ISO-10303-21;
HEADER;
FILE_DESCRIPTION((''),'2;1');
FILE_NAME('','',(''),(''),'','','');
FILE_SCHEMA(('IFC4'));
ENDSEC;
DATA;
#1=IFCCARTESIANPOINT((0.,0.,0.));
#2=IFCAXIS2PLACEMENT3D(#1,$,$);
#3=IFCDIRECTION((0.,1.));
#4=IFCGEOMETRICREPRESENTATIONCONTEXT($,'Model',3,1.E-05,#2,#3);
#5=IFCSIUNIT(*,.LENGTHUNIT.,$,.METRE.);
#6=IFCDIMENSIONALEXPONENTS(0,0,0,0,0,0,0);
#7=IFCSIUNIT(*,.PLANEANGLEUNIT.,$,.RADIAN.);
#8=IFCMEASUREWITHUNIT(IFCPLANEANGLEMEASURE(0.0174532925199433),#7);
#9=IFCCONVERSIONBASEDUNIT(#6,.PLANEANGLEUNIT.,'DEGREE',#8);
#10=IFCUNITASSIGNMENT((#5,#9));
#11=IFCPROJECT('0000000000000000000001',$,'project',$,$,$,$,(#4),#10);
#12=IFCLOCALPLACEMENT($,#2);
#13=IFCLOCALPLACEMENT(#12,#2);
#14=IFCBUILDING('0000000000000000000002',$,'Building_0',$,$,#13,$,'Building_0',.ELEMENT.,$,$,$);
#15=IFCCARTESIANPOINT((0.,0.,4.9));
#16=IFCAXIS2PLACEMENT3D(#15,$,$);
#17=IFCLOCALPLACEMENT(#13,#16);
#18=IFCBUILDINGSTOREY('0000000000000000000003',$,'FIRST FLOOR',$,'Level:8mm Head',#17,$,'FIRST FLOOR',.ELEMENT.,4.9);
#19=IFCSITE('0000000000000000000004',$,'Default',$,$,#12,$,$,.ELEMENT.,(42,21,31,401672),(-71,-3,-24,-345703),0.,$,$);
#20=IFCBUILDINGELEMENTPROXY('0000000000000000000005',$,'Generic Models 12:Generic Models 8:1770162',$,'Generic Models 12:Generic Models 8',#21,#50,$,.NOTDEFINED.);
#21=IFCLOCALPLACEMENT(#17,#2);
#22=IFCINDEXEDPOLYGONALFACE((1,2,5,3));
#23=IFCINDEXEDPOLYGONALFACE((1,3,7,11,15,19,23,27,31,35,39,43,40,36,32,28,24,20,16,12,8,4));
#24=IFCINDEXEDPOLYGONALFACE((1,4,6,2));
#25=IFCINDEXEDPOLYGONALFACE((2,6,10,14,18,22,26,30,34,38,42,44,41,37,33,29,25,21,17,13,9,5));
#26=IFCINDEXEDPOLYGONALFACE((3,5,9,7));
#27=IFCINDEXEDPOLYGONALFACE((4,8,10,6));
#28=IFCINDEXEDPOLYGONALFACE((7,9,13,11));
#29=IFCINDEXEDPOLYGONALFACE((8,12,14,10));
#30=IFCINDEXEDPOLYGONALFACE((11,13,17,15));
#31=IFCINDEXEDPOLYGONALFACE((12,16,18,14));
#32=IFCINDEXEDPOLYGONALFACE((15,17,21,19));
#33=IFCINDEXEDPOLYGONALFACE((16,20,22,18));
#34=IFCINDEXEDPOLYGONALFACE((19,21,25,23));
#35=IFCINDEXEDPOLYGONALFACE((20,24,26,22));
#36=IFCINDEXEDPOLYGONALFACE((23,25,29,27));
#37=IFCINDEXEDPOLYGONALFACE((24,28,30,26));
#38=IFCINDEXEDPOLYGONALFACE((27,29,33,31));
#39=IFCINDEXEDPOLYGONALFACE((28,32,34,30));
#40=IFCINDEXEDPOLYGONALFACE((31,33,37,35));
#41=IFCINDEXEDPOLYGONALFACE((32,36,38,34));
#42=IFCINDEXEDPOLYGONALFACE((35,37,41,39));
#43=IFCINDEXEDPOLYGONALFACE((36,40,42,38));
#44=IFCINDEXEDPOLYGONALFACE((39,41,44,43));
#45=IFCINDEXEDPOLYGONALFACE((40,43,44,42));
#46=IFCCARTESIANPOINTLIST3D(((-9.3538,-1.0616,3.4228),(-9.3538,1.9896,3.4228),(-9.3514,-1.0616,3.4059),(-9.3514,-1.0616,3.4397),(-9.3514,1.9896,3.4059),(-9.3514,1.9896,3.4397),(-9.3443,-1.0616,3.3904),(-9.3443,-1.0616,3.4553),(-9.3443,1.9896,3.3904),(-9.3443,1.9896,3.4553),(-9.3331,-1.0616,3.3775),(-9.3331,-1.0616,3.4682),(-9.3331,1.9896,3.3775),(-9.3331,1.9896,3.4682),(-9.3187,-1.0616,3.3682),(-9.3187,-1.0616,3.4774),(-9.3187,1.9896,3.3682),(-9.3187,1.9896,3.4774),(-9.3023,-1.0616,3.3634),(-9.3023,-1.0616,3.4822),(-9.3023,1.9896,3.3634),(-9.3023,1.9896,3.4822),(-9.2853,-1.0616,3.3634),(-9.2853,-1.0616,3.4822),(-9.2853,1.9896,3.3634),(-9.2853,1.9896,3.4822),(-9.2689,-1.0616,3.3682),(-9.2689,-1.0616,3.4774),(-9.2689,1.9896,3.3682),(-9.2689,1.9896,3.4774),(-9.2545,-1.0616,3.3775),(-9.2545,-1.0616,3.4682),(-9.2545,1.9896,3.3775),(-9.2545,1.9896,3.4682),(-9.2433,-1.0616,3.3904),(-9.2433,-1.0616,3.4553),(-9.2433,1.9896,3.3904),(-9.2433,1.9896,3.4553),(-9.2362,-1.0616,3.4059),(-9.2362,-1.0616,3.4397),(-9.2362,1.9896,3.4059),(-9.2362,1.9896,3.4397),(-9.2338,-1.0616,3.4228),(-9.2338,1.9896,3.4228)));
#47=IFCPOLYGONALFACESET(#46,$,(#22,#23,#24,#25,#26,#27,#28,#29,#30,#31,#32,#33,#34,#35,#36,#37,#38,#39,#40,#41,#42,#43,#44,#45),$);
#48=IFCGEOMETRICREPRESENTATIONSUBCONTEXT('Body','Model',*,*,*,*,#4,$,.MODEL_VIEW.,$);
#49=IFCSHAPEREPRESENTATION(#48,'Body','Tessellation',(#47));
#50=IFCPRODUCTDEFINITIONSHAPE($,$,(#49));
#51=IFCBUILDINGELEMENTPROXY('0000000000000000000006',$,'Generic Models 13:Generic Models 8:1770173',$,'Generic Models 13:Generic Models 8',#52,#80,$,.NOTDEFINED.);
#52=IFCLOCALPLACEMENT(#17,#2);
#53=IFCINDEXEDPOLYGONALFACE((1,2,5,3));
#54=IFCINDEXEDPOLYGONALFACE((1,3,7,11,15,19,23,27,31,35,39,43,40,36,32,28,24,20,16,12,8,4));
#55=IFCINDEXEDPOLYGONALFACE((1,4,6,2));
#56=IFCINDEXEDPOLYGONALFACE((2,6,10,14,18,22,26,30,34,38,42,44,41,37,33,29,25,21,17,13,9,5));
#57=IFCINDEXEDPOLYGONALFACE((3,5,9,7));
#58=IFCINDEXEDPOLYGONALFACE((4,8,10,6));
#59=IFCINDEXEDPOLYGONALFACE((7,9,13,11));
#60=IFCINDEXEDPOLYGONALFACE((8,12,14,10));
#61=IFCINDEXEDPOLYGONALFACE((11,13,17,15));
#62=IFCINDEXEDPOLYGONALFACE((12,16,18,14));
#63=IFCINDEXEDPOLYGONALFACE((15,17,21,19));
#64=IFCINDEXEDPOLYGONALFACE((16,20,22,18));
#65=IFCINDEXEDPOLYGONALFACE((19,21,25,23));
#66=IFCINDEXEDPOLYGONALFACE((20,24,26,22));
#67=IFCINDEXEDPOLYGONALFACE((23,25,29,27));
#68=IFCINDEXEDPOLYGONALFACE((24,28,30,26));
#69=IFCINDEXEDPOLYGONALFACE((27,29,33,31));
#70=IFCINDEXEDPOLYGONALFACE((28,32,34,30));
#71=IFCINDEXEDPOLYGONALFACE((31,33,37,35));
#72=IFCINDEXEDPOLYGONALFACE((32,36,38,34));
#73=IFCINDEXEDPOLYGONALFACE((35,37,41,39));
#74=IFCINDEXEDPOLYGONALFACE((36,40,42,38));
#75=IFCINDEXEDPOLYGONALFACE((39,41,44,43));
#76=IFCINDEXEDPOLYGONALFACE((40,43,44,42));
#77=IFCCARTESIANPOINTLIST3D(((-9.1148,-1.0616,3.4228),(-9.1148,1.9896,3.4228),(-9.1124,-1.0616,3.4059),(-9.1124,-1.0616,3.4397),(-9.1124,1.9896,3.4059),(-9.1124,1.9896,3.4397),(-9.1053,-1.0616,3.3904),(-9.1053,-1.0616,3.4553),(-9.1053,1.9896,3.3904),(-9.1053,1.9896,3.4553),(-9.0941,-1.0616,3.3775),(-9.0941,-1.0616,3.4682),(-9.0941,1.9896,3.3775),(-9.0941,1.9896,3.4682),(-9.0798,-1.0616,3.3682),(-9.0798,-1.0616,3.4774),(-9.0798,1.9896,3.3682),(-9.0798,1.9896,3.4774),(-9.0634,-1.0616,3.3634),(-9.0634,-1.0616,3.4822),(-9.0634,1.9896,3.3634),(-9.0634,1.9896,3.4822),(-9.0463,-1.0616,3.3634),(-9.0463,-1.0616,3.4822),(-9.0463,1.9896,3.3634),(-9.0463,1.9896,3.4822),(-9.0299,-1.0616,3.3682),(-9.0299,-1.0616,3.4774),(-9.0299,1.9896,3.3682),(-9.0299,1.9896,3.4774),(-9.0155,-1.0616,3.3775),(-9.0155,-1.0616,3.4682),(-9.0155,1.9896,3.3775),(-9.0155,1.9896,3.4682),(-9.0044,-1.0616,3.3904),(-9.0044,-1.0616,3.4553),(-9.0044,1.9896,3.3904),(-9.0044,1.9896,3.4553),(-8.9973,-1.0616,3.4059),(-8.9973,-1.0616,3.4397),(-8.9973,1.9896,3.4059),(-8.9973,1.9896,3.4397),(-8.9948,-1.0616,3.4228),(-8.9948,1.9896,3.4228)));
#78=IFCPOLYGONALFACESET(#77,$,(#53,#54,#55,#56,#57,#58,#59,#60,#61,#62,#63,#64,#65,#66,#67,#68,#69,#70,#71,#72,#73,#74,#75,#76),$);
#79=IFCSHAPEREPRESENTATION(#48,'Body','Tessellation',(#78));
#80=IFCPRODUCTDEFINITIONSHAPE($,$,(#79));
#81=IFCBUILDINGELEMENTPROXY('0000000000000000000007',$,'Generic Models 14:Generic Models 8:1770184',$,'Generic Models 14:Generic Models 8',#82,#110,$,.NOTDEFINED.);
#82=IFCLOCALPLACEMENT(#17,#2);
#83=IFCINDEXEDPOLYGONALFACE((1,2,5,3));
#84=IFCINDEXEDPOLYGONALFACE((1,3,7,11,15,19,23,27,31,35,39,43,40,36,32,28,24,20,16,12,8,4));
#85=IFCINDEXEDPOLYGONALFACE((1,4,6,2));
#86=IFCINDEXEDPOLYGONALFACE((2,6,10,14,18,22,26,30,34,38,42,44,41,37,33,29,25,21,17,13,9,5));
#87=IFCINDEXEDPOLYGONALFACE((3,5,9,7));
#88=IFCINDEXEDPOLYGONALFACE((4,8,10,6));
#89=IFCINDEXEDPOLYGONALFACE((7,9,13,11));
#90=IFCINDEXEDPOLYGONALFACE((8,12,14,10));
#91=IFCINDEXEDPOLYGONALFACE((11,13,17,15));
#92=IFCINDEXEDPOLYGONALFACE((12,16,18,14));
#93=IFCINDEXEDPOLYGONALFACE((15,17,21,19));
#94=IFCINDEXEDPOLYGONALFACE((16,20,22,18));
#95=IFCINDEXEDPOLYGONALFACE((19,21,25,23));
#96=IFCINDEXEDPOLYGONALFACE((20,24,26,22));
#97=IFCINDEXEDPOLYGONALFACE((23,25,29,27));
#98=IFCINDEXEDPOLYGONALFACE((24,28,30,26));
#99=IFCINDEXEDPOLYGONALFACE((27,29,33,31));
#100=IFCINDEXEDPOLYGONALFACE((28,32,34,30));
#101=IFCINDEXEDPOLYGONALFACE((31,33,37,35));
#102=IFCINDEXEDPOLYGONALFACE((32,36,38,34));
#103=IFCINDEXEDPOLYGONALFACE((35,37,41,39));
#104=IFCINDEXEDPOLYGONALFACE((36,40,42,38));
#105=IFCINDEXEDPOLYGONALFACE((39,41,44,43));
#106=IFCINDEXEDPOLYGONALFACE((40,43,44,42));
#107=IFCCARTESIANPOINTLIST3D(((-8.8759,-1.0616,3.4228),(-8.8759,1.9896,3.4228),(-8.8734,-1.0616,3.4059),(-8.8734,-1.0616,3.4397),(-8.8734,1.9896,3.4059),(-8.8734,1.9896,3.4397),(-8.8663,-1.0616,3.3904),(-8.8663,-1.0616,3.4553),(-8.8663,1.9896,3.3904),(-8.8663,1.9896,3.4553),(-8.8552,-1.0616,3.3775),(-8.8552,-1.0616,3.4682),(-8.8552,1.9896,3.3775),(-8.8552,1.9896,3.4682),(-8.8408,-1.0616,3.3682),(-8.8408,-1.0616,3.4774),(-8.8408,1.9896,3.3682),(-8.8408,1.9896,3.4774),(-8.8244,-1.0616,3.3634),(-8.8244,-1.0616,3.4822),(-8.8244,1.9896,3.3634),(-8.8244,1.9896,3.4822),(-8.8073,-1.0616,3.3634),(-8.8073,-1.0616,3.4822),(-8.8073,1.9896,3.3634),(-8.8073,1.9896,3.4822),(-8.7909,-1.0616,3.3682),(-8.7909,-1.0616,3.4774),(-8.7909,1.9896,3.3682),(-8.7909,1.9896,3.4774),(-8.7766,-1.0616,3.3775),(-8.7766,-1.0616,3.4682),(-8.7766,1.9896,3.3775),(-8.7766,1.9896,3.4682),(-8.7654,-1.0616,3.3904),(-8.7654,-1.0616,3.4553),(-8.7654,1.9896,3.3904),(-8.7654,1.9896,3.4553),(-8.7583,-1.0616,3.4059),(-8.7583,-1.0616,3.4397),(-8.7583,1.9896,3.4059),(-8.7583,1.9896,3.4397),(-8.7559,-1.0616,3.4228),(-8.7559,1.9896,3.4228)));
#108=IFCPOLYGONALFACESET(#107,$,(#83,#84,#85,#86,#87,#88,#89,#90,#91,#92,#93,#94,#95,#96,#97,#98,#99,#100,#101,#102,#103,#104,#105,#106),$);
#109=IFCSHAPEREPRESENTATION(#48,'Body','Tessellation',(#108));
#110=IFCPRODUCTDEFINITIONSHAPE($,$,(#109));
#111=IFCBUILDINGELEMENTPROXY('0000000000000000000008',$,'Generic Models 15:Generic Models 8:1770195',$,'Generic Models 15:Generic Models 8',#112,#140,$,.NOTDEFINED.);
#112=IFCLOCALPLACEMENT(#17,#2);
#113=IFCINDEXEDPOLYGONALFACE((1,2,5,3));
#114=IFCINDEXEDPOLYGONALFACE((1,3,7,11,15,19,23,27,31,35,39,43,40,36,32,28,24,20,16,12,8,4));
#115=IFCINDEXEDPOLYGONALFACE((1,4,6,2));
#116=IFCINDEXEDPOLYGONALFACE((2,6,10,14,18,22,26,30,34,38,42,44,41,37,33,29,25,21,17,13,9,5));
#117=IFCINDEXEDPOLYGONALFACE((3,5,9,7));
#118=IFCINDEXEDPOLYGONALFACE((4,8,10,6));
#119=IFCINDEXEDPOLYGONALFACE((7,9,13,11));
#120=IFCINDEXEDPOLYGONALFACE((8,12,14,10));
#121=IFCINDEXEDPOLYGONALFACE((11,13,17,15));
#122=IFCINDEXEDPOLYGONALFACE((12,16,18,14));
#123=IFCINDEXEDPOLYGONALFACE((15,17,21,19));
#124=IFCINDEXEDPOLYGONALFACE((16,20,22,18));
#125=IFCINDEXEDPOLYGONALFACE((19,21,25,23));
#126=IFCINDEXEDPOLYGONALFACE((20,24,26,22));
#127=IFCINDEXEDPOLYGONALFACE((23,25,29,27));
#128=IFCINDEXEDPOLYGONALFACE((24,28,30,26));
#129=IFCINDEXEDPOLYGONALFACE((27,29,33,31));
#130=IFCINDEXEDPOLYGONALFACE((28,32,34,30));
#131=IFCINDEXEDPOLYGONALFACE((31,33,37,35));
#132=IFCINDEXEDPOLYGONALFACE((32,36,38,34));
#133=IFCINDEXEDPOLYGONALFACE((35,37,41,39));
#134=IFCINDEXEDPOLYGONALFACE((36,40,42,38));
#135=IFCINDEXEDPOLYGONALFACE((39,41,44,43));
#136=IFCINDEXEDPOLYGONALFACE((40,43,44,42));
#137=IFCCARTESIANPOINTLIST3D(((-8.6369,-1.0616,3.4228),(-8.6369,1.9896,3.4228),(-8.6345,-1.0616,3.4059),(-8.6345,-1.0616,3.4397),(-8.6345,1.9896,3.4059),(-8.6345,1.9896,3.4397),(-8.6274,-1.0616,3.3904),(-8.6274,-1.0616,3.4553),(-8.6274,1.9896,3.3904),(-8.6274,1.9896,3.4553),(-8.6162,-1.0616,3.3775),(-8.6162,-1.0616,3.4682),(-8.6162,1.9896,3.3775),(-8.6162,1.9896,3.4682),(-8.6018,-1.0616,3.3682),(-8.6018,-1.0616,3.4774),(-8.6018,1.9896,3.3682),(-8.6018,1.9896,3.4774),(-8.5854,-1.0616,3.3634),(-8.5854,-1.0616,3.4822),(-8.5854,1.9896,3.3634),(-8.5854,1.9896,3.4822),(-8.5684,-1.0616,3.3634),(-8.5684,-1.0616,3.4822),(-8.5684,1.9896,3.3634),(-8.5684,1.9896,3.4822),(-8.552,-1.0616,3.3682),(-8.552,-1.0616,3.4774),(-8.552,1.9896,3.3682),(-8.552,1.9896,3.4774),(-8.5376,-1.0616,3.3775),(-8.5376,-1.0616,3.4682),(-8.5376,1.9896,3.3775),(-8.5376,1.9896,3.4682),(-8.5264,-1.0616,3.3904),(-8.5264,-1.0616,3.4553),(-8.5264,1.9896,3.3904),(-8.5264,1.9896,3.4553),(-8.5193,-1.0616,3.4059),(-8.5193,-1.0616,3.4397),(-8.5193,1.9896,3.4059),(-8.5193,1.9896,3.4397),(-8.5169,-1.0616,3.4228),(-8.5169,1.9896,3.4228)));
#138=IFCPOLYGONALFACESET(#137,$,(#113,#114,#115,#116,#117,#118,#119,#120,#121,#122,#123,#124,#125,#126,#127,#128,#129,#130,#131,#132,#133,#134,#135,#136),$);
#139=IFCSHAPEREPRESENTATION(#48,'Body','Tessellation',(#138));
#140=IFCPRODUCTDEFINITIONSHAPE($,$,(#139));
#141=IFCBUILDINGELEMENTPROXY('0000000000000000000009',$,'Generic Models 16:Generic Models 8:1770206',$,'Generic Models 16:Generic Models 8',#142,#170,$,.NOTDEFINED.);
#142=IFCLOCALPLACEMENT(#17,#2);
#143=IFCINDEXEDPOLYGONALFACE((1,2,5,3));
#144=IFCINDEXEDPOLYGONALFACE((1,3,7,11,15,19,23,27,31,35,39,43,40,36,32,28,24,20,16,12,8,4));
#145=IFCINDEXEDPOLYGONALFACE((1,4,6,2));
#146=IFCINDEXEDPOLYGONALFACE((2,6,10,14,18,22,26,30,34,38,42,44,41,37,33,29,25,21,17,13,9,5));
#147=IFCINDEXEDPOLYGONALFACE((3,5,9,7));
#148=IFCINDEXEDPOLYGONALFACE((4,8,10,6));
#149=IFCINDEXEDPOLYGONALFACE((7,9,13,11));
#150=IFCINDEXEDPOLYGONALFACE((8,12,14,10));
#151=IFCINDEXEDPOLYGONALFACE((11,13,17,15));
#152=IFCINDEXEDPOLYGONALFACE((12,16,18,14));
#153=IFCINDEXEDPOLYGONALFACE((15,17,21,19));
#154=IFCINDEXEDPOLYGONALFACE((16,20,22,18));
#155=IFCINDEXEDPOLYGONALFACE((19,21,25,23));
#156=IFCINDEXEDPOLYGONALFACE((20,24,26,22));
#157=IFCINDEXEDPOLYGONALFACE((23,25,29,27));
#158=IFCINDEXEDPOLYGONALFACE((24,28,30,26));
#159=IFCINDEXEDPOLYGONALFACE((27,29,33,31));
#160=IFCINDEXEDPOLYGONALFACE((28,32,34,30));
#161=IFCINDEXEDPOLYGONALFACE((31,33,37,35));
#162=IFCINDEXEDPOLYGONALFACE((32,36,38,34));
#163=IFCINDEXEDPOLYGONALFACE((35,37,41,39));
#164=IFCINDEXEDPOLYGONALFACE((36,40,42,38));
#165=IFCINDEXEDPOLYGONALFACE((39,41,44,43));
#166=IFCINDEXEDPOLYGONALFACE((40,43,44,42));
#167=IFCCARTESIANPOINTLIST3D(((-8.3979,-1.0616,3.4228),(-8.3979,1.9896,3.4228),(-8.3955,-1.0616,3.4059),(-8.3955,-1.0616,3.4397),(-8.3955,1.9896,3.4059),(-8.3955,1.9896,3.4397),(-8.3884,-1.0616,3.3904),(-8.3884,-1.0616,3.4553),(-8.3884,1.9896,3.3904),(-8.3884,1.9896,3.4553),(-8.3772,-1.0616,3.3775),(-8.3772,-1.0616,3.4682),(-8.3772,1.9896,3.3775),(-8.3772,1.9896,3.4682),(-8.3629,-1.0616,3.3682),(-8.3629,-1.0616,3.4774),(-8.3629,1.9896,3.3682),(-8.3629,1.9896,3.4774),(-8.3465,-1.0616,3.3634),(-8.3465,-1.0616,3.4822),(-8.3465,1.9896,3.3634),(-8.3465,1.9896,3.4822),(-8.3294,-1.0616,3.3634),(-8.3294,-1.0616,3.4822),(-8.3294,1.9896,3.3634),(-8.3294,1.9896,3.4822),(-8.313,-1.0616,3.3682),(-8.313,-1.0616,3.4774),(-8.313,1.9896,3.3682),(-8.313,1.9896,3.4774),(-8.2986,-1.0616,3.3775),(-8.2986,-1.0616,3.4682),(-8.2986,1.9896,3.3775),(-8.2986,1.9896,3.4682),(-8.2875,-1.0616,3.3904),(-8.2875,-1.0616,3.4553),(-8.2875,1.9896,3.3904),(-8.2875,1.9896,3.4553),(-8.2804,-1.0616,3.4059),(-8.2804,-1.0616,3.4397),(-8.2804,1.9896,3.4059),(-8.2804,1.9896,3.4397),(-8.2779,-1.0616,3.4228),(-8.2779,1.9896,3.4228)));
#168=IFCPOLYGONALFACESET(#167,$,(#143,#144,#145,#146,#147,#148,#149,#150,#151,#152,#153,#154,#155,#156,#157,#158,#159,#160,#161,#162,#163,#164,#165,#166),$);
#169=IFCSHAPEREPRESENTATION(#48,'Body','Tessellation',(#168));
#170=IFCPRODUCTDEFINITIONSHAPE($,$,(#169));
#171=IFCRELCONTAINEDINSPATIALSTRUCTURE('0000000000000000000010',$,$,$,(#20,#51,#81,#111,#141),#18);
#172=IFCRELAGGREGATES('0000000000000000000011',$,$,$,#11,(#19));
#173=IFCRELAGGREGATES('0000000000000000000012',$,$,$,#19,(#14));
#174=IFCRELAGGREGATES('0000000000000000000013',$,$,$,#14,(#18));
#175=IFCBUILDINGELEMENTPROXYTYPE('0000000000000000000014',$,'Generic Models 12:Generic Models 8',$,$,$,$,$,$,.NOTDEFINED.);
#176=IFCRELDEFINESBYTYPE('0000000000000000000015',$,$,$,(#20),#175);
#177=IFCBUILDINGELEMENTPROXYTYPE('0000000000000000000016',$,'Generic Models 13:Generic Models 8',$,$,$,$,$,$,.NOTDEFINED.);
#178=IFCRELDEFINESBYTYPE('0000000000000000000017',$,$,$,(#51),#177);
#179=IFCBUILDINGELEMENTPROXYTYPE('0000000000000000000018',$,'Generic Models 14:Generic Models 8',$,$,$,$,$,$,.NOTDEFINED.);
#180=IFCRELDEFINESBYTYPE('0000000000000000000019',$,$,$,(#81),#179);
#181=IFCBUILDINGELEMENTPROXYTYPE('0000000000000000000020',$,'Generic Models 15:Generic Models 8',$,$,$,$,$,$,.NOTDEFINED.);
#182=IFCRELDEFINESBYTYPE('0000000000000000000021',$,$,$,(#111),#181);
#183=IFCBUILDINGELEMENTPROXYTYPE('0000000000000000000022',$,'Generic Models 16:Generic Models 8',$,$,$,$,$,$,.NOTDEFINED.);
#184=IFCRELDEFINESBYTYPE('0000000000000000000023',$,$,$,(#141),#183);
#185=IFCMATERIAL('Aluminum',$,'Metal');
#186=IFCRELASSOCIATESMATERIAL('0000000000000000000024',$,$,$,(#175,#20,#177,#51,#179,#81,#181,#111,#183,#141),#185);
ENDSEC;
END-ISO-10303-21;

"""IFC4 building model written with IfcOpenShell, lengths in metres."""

from ifc_helpers import new_model, entity, si_unit, converted_unit, direction, frame, origin, place, context, subcontext, project, spatial, arc, indexed_curve, outline, extrude, source, transform, mapped, material, type_object, type_shapes, element, save


model = new_model("IFC4")

# Units and contexts
model_context = context("Model", 3, precision=1e-05, world=origin(), true_north=direction((0.0, 1.0)))
body_context = subcontext(model_context, "Body", "Model", "MODEL_VIEW")
ifc_project = project(units=[si_unit("LENGTHUNIT", "METRE"), converted_unit("PLANEANGLEUNIT", "DEGREE", entity("IfcPlaneAngleMeasure", 0.0174532925199433), si_unit("PLANEANGLEUNIT", "RADIAN"), dimensions=[0, 0, 0, 0, 0, 0, 0])], contexts=[model_context])

# Site, building, storey
site_placement = place(None, origin())
site = spatial("IfcSite", under=ifc_project, at=site_placement, Name="Default", CompositionType="ELEMENT", RefLatitude=(42, 21, 31, 401672), RefLongitude=(-71, -3, -24, -345703), RefElevation=0.0)
building_placement = place(site_placement, origin())
building = spatial("IfcBuilding", under=site, at=building_placement, Name="Building_0", LongName="Building_0", CompositionType="ELEMENT")
storey_placement = place(building_placement, frame((0.0, 0.0, 4.9)))
storey = spatial("IfcBuildingStorey", under=building, at=storey_placement, Name="FIRST FLOOR", ObjectType="Level:8mm Head", LongName="FIRST FLOOR", CompositionType="ELEMENT", Elevation=4.9)

# Building element proxies
ifc_material = material(Name="Aluminum", Category="Metal")
building_element_proxy_type_1 = type_object("IfcBuildingElementProxyType", Name="Generic Models 12:Generic Models 8", PredefinedType="NOTDEFINED", material=ifc_material)
shared_shape_1 = source(origin(), body_context, "Body", "SweptSolid", [
    extrude(outline(indexed_curve([(-0.06, 0.0), (0.0, -0.06), (0.06, 0.0), (0.0, 0.06)], segments=[arc(1, 2, 3), arc(3, 4, 1)], self_intersect=False)), frame((-9.2938, -1.0616, 8.3228), z_axis=(0.0, 1.0, 0.0), x_axis=(-1.0, 0.0, 0.0)), (0.0, 0.0, 1.0), 3.0512),
])
type_shapes(building_element_proxy_type_1, [shared_shape_1])
proxy_1_placement = place(storey_placement, frame((0.0, 0.0, -4.9)))
element("IfcBuildingElementProxy", 1, at=proxy_1_placement, inside=storey, type_object=building_element_proxy_type_1, material=ifc_material, Name="Generic Models 12:Generic Models 8:1770162", ObjectType="Generic Models 12:Generic Models 8", PredefinedType="NOTDEFINED", context=body_context, shape_type="MappedRepresentation", body=[
    mapped(shared_shape_1, transform((0.0, 0.0, 0.0), scale=1.0)),
])
building_element_proxy_type_2 = type_object("IfcBuildingElementProxyType", Name="Generic Models 13:Generic Models 8", PredefinedType="NOTDEFINED", material=ifc_material)
shared_shape_2 = source(origin(), body_context, "Body", "SweptSolid", [
    extrude(outline(indexed_curve([(-0.06, 0.0), (0.0, -0.06), (0.06, 0.0), (0.0, 0.06)], segments=[arc(1, 2, 3), arc(3, 4, 1)], self_intersect=False)), frame((-9.0548, -1.0616, 8.3228), z_axis=(0.0, 1.0, 0.0), x_axis=(-1.0, 0.0, 0.0)), (0.0, 0.0, 1.0), 3.0512),
])
type_shapes(building_element_proxy_type_2, [shared_shape_2])
proxy_2_placement = place(storey_placement, frame((0.0, 0.0, -4.9)))
element("IfcBuildingElementProxy", 2, at=proxy_2_placement, inside=storey, type_object=building_element_proxy_type_2, material=ifc_material, Name="Generic Models 13:Generic Models 8:1770173", ObjectType="Generic Models 13:Generic Models 8", PredefinedType="NOTDEFINED", context=body_context, shape_type="MappedRepresentation", body=[
    mapped(shared_shape_2, transform((0.0, 0.0, 0.0), scale=1.0)),
])
building_element_proxy_type_3 = type_object("IfcBuildingElementProxyType", Name="Generic Models 14:Generic Models 8", PredefinedType="NOTDEFINED", material=ifc_material)
shared_shape_3 = source(origin(), body_context, "Body", "SweptSolid", [
    extrude(outline(indexed_curve([(-0.06, 0.0), (0.0, -0.06), (0.06, 0.0), (0.0, 0.06)], segments=[arc(1, 2, 3), arc(3, 4, 1)], self_intersect=False)), frame((-8.8159, -1.0616, 8.3228), z_axis=(0.0, 1.0, 0.0), x_axis=(-1.0, 0.0, 0.0)), (0.0, 0.0, 1.0), 3.0512),
])
type_shapes(building_element_proxy_type_3, [shared_shape_3])
proxy_3_placement = place(storey_placement, frame((0.0, 0.0, -4.9)))
element("IfcBuildingElementProxy", 3, at=proxy_3_placement, inside=storey, type_object=building_element_proxy_type_3, material=ifc_material, Name="Generic Models 14:Generic Models 8:1770184", ObjectType="Generic Models 14:Generic Models 8", PredefinedType="NOTDEFINED", context=body_context, shape_type="MappedRepresentation", body=[
    mapped(shared_shape_3, transform((0.0, 0.0, 0.0), scale=1.0)),
])
building_element_proxy_type_4 = type_object("IfcBuildingElementProxyType", Name="Generic Models 15:Generic Models 8", PredefinedType="NOTDEFINED", material=ifc_material)
shared_shape_4 = source(origin(), body_context, "Body", "SweptSolid", [
    extrude(outline(indexed_curve([(-0.06, 0.0), (0.0, -0.06), (0.06, 0.0), (0.0, 0.06)], segments=[arc(1, 2, 3), arc(3, 4, 1)], self_intersect=False)), frame((-8.5769, -1.0616, 8.3228), z_axis=(0.0, 1.0, 0.0), x_axis=(-1.0, 0.0, 0.0)), (0.0, 0.0, 1.0), 3.0512),
])
type_shapes(building_element_proxy_type_4, [shared_shape_4])
proxy_4_placement = place(storey_placement, frame((0.0, 0.0, -4.9)))
element("IfcBuildingElementProxy", 4, at=proxy_4_placement, inside=storey, type_object=building_element_proxy_type_4, material=ifc_material, Name="Generic Models 15:Generic Models 8:1770195", ObjectType="Generic Models 15:Generic Models 8", PredefinedType="NOTDEFINED", context=body_context, shape_type="MappedRepresentation", body=[
    mapped(shared_shape_4, transform((0.0, 0.0, 0.0), scale=1.0)),
])
building_element_proxy_type_5 = type_object("IfcBuildingElementProxyType", Name="Generic Models 16:Generic Models 8", PredefinedType="NOTDEFINED", material=ifc_material)
shared_shape_5 = source(origin(), body_context, "Body", "SweptSolid", [
    extrude(outline(indexed_curve([(-0.06, 0.0), (0.0, -0.06), (0.06, 0.0), (0.0, 0.06)], segments=[arc(1, 2, 3), arc(3, 4, 1)], self_intersect=False)), frame((-8.3379, -1.0616, 8.3228), z_axis=(0.0, 1.0, 0.0), x_axis=(-1.0, 0.0, 0.0)), (0.0, 0.0, 1.0), 3.0512),
])
type_shapes(building_element_proxy_type_5, [shared_shape_5])
proxy_5_placement = place(storey_placement, frame((0.0, 0.0, -4.9)))
element("IfcBuildingElementProxy", 5, at=proxy_5_placement, inside=storey, type_object=building_element_proxy_type_5, material=ifc_material, Name="Generic Models 16:Generic Models 8:1770206", ObjectType="Generic Models 16:Generic Models 8", PredefinedType="NOTDEFINED", context=body_context, shape_type="MappedRepresentation", body=[
    mapped(shared_shape_5, transform((0.0, 0.0, 0.0), scale=1.0)),
])

save(model, "model.ifc")
